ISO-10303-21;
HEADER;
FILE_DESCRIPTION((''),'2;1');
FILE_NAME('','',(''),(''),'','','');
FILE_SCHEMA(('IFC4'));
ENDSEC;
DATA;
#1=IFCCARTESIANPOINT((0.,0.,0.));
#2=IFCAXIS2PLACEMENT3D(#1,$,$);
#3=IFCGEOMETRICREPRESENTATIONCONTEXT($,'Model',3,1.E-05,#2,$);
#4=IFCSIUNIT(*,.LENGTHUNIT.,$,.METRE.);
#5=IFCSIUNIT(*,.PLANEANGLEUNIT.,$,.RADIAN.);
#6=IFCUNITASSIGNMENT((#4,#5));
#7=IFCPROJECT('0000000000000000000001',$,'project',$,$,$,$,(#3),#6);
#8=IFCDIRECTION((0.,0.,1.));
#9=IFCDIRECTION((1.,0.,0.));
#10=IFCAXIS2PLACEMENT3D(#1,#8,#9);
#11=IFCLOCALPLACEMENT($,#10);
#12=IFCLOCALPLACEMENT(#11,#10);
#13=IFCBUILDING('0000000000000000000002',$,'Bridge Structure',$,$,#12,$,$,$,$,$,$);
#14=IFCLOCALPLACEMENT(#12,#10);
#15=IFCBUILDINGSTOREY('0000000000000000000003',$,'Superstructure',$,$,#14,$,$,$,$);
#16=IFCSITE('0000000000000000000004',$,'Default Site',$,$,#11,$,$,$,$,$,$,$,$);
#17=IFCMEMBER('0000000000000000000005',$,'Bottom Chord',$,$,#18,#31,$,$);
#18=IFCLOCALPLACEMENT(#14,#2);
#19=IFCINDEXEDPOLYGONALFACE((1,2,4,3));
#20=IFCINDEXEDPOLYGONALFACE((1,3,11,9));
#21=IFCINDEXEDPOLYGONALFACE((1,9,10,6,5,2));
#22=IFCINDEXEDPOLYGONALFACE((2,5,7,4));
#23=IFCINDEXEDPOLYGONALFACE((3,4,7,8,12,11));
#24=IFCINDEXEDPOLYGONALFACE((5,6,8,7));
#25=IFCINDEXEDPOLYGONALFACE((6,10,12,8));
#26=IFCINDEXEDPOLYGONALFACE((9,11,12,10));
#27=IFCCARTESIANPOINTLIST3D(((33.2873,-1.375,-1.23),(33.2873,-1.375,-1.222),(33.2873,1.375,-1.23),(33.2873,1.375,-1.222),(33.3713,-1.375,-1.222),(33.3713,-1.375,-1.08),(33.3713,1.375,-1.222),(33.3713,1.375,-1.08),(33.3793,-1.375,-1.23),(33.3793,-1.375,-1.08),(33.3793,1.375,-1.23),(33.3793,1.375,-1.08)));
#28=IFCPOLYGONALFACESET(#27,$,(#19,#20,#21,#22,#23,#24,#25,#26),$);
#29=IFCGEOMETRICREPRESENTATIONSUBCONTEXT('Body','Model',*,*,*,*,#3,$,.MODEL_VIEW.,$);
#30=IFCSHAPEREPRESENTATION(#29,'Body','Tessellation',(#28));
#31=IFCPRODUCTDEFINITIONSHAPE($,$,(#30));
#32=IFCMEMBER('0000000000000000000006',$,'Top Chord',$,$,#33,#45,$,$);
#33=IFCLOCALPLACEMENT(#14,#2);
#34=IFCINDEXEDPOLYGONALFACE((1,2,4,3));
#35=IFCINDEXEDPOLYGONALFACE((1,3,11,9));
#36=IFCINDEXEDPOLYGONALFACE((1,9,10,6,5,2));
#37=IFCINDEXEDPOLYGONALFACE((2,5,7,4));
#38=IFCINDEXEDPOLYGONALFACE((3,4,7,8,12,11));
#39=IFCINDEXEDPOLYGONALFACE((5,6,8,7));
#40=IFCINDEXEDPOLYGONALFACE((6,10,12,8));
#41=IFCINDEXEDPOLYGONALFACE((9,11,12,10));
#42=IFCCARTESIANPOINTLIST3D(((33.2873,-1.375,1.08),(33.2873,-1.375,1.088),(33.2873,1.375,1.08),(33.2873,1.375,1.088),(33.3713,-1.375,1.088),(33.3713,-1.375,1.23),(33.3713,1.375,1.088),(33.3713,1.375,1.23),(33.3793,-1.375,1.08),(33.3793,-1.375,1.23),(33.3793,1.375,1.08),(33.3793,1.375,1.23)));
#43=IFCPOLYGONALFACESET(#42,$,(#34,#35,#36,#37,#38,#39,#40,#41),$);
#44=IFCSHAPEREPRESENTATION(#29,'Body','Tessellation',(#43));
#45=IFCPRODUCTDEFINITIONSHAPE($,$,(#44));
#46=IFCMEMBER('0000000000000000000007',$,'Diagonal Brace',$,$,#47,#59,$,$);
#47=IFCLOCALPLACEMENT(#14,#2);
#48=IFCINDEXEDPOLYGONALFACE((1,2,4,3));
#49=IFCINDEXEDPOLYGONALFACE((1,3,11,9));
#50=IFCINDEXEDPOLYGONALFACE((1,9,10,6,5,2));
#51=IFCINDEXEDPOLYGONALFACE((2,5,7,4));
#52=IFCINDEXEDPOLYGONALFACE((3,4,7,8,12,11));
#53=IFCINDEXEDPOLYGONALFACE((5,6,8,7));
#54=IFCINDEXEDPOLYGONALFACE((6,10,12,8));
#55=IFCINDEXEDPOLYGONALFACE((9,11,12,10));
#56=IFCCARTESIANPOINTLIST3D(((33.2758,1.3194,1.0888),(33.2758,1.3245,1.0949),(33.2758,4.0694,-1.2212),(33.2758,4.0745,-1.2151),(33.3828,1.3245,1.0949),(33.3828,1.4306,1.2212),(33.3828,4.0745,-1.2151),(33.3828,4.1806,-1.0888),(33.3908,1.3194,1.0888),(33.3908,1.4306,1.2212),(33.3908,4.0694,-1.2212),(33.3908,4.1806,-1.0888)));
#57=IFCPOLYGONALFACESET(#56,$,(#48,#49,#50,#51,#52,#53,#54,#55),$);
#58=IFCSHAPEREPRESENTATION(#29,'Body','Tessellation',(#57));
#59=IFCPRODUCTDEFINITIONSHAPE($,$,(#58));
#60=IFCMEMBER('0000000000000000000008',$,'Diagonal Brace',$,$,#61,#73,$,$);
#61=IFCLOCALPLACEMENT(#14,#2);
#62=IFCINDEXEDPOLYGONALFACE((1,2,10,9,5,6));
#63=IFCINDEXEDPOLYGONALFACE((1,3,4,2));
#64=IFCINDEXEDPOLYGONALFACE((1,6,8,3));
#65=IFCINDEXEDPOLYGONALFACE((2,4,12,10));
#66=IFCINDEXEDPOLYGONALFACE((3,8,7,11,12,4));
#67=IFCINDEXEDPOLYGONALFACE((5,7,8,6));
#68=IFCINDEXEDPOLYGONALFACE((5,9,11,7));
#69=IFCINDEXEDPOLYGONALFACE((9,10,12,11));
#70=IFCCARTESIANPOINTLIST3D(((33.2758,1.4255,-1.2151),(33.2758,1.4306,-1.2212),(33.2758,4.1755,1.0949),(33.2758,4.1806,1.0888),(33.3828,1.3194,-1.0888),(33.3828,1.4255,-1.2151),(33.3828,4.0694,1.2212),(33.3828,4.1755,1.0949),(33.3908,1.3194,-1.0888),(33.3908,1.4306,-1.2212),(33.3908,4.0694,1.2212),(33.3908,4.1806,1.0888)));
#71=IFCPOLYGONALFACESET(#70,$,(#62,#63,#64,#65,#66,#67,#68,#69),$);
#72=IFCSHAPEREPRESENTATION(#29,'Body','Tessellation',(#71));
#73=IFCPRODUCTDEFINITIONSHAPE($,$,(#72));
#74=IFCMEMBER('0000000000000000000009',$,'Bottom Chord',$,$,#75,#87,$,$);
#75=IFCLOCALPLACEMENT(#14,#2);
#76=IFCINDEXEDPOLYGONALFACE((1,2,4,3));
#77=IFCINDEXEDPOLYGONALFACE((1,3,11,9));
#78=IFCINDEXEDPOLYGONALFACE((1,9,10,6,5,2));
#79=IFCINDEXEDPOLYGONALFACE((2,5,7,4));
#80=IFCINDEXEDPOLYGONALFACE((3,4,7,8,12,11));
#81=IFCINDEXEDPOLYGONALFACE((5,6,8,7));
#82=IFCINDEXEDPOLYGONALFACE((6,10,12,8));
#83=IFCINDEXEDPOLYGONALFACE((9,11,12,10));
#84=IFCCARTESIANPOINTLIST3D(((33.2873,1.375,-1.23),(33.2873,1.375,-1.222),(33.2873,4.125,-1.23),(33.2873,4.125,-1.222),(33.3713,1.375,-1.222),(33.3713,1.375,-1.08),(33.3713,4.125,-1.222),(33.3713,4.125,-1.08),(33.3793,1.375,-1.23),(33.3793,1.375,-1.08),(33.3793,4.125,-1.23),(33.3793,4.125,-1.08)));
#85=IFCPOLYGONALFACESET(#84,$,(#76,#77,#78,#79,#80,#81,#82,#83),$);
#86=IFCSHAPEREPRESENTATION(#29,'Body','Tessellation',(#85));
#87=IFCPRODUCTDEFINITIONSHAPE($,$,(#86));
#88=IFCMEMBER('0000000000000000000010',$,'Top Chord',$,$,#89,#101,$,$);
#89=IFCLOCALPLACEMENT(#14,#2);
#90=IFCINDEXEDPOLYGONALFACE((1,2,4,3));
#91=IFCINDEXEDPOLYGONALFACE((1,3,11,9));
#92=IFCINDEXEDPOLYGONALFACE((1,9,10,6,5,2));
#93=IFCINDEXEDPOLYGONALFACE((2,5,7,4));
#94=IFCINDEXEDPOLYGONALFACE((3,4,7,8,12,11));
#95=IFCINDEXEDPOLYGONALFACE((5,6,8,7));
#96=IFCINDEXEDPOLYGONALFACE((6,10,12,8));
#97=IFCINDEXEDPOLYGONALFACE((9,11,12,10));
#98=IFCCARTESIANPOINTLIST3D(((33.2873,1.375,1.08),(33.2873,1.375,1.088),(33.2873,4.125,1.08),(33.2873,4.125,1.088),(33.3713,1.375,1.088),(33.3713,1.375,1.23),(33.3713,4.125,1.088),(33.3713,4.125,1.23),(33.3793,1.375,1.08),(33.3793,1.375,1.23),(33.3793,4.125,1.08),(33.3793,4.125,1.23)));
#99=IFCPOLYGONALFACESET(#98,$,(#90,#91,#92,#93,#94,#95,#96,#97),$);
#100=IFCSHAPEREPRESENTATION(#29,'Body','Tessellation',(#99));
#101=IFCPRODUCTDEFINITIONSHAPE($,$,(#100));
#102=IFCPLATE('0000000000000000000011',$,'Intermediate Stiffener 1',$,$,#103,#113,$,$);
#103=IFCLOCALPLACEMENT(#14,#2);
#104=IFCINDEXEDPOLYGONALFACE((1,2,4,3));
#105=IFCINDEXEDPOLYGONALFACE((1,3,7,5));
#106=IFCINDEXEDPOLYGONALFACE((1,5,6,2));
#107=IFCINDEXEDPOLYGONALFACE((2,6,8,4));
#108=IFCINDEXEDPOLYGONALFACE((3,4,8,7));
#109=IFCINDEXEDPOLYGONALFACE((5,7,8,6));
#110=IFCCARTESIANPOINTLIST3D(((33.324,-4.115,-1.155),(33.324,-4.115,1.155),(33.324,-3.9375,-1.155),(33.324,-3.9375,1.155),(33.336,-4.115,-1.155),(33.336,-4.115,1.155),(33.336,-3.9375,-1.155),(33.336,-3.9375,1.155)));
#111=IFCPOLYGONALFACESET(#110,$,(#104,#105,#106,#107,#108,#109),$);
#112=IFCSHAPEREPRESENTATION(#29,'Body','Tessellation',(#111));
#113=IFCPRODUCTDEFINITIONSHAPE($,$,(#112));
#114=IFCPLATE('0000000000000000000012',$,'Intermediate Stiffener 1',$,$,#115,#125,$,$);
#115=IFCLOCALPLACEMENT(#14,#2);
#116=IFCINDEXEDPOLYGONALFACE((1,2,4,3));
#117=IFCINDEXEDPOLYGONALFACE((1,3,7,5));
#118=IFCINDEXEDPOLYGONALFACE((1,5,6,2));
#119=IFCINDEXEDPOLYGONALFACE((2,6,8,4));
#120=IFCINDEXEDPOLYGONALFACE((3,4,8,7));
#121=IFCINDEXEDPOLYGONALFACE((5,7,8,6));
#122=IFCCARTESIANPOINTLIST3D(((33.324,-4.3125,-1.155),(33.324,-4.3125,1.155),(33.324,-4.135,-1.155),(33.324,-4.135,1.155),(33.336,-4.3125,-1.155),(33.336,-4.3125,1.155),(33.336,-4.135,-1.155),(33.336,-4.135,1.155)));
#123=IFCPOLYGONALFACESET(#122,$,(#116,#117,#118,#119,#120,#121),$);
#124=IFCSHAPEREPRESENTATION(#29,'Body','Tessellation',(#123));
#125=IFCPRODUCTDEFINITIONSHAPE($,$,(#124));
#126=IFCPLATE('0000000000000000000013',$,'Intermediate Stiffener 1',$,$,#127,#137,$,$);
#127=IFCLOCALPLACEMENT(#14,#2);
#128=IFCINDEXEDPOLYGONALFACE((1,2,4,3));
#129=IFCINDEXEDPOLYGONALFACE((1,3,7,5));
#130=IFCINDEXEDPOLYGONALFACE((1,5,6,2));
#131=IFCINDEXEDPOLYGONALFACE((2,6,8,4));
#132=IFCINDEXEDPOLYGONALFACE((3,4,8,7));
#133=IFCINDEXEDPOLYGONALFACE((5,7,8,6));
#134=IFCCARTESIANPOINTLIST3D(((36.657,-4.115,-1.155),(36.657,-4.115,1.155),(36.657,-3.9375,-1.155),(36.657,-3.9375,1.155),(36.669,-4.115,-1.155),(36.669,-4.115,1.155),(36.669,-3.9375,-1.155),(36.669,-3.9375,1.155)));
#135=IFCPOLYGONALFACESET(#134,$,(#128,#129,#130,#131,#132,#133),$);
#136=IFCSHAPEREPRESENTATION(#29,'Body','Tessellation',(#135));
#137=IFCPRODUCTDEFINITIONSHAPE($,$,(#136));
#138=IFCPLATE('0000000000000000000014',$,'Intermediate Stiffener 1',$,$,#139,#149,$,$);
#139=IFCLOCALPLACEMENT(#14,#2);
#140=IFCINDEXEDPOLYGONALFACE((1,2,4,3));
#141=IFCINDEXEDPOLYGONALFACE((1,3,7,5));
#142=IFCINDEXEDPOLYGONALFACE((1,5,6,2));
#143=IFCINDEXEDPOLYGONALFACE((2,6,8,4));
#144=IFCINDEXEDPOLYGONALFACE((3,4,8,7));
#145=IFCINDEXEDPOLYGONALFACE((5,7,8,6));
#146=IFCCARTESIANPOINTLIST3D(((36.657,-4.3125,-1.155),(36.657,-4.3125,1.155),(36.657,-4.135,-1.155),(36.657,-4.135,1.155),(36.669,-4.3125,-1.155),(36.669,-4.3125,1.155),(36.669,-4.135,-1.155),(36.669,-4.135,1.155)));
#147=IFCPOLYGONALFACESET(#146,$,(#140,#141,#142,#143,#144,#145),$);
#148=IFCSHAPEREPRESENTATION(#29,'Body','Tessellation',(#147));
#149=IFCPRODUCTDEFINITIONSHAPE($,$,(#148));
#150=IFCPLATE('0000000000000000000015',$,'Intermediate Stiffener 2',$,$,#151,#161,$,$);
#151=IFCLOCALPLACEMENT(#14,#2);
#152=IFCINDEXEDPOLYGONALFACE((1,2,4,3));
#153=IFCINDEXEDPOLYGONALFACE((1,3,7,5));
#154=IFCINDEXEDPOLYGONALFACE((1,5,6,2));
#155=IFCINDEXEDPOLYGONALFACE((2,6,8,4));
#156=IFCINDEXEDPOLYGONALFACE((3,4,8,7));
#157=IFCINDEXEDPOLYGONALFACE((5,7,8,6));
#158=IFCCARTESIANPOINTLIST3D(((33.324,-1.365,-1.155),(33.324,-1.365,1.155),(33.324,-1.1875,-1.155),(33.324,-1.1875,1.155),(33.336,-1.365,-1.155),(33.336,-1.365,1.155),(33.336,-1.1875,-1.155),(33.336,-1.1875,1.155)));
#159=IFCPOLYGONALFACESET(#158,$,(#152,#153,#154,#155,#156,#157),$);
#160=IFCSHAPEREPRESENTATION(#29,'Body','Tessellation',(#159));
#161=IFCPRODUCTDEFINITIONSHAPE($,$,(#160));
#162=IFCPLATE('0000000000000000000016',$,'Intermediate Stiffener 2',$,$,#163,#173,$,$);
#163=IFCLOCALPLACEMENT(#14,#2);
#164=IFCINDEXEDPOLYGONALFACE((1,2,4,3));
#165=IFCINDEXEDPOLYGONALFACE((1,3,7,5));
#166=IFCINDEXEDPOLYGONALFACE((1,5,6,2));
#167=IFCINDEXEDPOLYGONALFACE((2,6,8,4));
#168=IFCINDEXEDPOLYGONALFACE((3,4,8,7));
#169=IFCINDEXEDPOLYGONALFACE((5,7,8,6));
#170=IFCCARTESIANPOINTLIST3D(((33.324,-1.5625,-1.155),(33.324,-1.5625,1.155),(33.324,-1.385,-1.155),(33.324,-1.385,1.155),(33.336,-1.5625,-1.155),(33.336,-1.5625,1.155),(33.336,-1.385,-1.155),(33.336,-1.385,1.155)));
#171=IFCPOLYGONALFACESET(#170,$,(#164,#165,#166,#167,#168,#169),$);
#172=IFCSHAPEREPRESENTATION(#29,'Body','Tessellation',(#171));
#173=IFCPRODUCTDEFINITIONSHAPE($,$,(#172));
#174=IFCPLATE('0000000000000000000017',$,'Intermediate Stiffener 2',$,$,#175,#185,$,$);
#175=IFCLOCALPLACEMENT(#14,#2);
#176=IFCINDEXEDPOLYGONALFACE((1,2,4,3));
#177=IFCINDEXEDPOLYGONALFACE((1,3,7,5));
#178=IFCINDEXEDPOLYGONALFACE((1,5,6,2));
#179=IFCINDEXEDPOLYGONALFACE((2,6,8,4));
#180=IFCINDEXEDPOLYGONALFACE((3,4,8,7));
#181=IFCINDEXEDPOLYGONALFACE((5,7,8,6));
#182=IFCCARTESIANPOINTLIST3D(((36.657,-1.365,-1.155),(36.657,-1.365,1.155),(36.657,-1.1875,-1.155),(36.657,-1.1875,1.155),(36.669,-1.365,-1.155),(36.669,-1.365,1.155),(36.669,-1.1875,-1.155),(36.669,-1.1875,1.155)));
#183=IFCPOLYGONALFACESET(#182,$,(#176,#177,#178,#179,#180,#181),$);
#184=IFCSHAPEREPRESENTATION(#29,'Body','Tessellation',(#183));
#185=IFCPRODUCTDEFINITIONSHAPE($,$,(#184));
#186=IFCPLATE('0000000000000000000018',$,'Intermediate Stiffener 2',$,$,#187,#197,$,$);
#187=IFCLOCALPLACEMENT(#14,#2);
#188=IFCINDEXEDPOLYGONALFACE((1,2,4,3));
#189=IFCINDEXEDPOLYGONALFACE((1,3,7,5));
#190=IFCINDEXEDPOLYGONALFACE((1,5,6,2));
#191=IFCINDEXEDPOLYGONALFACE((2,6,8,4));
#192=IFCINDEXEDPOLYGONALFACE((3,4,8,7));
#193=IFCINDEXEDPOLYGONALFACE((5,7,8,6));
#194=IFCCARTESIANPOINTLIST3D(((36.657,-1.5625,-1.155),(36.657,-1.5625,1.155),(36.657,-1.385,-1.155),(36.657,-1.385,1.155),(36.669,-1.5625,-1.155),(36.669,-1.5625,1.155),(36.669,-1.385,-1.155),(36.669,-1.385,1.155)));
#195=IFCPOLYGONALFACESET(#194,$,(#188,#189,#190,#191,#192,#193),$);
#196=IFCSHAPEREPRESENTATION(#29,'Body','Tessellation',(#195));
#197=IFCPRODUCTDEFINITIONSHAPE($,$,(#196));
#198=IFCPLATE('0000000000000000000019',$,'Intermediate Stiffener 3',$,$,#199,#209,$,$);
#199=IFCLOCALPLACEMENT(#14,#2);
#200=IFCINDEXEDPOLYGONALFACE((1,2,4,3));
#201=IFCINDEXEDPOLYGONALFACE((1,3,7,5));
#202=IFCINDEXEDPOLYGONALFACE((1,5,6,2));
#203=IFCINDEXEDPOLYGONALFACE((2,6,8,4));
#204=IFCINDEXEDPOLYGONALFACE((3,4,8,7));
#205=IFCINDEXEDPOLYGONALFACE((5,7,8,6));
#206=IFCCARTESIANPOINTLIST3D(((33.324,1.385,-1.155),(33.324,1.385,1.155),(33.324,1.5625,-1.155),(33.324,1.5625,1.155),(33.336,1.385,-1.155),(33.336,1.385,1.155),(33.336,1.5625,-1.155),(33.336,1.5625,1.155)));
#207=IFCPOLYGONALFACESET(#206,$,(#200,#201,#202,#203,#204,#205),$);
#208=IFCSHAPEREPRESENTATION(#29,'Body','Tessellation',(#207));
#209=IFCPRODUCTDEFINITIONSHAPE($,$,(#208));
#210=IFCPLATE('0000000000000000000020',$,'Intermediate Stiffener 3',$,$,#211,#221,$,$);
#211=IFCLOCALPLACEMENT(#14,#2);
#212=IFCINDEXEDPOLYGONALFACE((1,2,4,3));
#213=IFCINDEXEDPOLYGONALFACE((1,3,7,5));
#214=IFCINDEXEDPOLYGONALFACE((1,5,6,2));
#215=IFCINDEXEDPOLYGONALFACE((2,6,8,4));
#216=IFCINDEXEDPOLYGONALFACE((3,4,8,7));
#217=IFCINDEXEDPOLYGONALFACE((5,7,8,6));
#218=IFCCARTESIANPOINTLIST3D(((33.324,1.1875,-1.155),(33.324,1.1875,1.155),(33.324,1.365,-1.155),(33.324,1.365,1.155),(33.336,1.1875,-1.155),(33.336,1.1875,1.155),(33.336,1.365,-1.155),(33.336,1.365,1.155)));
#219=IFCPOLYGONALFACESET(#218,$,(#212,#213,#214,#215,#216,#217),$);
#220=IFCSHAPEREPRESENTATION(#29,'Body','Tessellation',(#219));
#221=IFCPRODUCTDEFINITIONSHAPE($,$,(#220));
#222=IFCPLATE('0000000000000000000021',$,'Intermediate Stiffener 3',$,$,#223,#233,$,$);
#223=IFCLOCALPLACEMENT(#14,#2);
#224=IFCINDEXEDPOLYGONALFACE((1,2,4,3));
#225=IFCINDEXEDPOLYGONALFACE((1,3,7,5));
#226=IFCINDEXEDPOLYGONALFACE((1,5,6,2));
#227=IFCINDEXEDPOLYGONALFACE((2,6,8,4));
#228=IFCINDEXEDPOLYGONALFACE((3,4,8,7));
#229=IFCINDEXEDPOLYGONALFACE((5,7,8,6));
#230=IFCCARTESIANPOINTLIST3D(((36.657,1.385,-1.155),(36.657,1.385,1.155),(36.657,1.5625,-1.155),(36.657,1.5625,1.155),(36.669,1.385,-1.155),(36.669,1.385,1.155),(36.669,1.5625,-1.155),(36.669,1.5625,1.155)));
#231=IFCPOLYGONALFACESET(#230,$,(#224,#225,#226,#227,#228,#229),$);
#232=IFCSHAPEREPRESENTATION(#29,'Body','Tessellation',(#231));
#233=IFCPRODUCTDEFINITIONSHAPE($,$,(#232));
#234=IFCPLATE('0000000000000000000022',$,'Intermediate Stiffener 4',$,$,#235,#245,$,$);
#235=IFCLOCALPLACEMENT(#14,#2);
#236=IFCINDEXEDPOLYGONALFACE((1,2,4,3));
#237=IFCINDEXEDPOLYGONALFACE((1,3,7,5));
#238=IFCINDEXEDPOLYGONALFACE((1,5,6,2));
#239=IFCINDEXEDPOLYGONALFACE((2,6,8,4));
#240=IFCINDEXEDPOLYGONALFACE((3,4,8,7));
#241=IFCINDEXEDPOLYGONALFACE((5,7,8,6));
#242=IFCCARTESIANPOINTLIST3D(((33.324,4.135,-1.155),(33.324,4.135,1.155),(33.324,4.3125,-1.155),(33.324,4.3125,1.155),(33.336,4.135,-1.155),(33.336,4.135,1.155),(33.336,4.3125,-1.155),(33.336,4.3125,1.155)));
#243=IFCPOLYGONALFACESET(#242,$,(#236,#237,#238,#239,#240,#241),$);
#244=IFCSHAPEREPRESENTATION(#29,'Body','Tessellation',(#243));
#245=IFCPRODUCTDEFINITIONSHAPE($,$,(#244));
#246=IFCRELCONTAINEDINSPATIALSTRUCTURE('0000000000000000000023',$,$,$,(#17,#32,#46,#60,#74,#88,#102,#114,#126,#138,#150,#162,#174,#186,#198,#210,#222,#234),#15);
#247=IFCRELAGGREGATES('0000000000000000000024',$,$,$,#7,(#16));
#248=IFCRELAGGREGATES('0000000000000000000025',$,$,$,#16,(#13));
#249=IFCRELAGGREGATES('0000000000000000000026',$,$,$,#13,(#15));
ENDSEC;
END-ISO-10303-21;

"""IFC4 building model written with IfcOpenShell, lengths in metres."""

from ifc_helpers import new_model, si_unit, frame, origin, origin_with_axes, origin_2d_with_axis, place, context, subcontext, project, spatial, rectangle, l_section, extrude, element, save


model = new_model("IFC4")

# Units and contexts
model_context = context("Model", 3, precision=1e-05, world=origin())
body_context = subcontext(model_context, "Body", "Model", "MODEL_VIEW")
ifc_project = project(units=[si_unit("LENGTHUNIT", "METRE"), si_unit("PLANEANGLEUNIT", "RADIAN")], contexts=[model_context])

# Site, building, storey
site_placement = place(None, origin_with_axes())
site = spatial("IfcSite", under=ifc_project, at=site_placement, Name="Default Site")
building_placement = place(site_placement, origin_with_axes())
building = spatial("IfcBuilding", under=site, at=building_placement, Name="Bridge Structure")
storey_placement = place(building_placement, origin_with_axes())
storey = spatial("IfcBuildingStorey", under=building, at=storey_placement, Name="Superstructure")

# Members
for number, where, z_axis, x_axis, name in (
    (1, (33.3333, -1.375, -1.155), (0.0, 1.0, 0.0), (-1.0, 0.0, 0.0), "Bottom Chord"),
    (2, (33.3333, -1.375, 1.155), (0.0, 1.0, 0.0), (-1.0, 0.0, 0.0), "Top Chord"),
):
    element("IfcMember", number, at=place(storey_placement, frame(where, z_axis=z_axis, x_axis=x_axis)), inside=storey, Name=name, context=body_context, shape_type="SweptSolid", body=[
        extrude(l_section(Depth=0.15, Width=0.092, Thickness=0.008, at=origin_2d_with_axis()), origin_with_axes(), (0.0, 0.0, 1.0), 2.75),
    ])
for number, where, z_axis, x_axis, name in (
    (3, (33.3333, 1.375, 1.155), (0.0, 0.765705, -0.643192), (-1.0, 0.0, 0.0), "Diagonal Brace"),
    (4, (33.3333, 1.375, -1.155), (0.0, 0.765705, 0.643192), (-1.0, 0.0, 0.0), "Diagonal Brace"),
):
    element("IfcMember", number, at=place(storey_placement, frame(where, z_axis=z_axis, x_axis=x_axis)), inside=storey, Name=name, context=body_context, shape_type="SweptSolid", body=[
        extrude(l_section(Depth=0.173, Width=0.115, Thickness=0.008, at=origin_2d_with_axis()), origin_with_axes(), (0.0, 0.0, 1.0), 3.5915),
    ])
for number, where, z_axis, x_axis, name in (
    (5, (33.3333, 1.375, -1.155), (0.0, 1.0, 0.0), (-1.0, 0.0, 0.0), "Bottom Chord"),
    (6, (33.3333, 1.375, 1.155), (0.0, 1.0, 0.0), (-1.0, 0.0, 0.0), "Top Chord"),
):
    element("IfcMember", number, at=place(storey_placement, frame(where, z_axis=z_axis, x_axis=x_axis)), inside=storey, Name=name, context=body_context, shape_type="SweptSolid", body=[
        extrude(l_section(Depth=0.15, Width=0.092, Thickness=0.008, at=origin_2d_with_axis()), origin_with_axes(), (0.0, 0.0, 1.0), 2.75),
    ])

# Plates
for number, where, z_axis, x_axis, name in (
    (7, (33.33, -4.0263, -1.155), (0.0, 0.0, 1.0), (1.0, 0.0, 0.0), "Intermediate Stiffener 1"),
    (8, (33.33, -4.2237, -1.155), (0.0, 0.0, 1.0), (1.0, 0.0, 0.0), "Intermediate Stiffener 1"),
    (9, (36.663, -4.0263, -1.155), (0.0, 0.0, 1.0), (1.0, 0.0, 0.0), "Intermediate Stiffener 1"),
    (10, (36.663, -4.2237, -1.155), (0.0, 0.0, 1.0), (1.0, 0.0, 0.0), "Intermediate Stiffener 1"),
    (11, (33.33, -1.2763, -1.155), (0.0, 0.0, 1.0), (1.0, 0.0, 0.0), "Intermediate Stiffener 2"),
    (12, (33.33, -1.4738, -1.155), (0.0, 0.0, 1.0), (1.0, 0.0, 0.0), "Intermediate Stiffener 2"),
    (13, (36.663, -1.2763, -1.155), (0.0, 0.0, 1.0), (1.0, 0.0, 0.0), "Intermediate Stiffener 2"),
    (14, (36.663, -1.4738, -1.155), (0.0, 0.0, 1.0), (1.0, 0.0, 0.0), "Intermediate Stiffener 2"),
    (15, (33.33, 1.4738, -1.155), (0.0, 0.0, 1.0), (1.0, 0.0, 0.0), "Intermediate Stiffener 3"),
    (16, (33.33, 1.2763, -1.155), (0.0, 0.0, 1.0), (1.0, 0.0, 0.0), "Intermediate Stiffener 3"),
    (17, (36.663, 1.4738, -1.155), (0.0, 0.0, 1.0), (1.0, 0.0, 0.0), "Intermediate Stiffener 3"),
    (18, (33.33, 4.2237, -1.155), (0.0, 0.0, 1.0), (1.0, 0.0, 0.0), "Intermediate Stiffener 4"),
):
    element("IfcPlate", number, at=place(storey_placement, frame(where, z_axis=z_axis, x_axis=x_axis)), inside=storey, Name=name, context=body_context, shape_type="SweptSolid", body=[
        extrude(rectangle(XDim=0.012, YDim=0.1775, at=origin_2d_with_axis()), origin_with_axes(), (0.0, 0.0, 1.0), 2.31),
    ])

save(model, "model.ifc")
